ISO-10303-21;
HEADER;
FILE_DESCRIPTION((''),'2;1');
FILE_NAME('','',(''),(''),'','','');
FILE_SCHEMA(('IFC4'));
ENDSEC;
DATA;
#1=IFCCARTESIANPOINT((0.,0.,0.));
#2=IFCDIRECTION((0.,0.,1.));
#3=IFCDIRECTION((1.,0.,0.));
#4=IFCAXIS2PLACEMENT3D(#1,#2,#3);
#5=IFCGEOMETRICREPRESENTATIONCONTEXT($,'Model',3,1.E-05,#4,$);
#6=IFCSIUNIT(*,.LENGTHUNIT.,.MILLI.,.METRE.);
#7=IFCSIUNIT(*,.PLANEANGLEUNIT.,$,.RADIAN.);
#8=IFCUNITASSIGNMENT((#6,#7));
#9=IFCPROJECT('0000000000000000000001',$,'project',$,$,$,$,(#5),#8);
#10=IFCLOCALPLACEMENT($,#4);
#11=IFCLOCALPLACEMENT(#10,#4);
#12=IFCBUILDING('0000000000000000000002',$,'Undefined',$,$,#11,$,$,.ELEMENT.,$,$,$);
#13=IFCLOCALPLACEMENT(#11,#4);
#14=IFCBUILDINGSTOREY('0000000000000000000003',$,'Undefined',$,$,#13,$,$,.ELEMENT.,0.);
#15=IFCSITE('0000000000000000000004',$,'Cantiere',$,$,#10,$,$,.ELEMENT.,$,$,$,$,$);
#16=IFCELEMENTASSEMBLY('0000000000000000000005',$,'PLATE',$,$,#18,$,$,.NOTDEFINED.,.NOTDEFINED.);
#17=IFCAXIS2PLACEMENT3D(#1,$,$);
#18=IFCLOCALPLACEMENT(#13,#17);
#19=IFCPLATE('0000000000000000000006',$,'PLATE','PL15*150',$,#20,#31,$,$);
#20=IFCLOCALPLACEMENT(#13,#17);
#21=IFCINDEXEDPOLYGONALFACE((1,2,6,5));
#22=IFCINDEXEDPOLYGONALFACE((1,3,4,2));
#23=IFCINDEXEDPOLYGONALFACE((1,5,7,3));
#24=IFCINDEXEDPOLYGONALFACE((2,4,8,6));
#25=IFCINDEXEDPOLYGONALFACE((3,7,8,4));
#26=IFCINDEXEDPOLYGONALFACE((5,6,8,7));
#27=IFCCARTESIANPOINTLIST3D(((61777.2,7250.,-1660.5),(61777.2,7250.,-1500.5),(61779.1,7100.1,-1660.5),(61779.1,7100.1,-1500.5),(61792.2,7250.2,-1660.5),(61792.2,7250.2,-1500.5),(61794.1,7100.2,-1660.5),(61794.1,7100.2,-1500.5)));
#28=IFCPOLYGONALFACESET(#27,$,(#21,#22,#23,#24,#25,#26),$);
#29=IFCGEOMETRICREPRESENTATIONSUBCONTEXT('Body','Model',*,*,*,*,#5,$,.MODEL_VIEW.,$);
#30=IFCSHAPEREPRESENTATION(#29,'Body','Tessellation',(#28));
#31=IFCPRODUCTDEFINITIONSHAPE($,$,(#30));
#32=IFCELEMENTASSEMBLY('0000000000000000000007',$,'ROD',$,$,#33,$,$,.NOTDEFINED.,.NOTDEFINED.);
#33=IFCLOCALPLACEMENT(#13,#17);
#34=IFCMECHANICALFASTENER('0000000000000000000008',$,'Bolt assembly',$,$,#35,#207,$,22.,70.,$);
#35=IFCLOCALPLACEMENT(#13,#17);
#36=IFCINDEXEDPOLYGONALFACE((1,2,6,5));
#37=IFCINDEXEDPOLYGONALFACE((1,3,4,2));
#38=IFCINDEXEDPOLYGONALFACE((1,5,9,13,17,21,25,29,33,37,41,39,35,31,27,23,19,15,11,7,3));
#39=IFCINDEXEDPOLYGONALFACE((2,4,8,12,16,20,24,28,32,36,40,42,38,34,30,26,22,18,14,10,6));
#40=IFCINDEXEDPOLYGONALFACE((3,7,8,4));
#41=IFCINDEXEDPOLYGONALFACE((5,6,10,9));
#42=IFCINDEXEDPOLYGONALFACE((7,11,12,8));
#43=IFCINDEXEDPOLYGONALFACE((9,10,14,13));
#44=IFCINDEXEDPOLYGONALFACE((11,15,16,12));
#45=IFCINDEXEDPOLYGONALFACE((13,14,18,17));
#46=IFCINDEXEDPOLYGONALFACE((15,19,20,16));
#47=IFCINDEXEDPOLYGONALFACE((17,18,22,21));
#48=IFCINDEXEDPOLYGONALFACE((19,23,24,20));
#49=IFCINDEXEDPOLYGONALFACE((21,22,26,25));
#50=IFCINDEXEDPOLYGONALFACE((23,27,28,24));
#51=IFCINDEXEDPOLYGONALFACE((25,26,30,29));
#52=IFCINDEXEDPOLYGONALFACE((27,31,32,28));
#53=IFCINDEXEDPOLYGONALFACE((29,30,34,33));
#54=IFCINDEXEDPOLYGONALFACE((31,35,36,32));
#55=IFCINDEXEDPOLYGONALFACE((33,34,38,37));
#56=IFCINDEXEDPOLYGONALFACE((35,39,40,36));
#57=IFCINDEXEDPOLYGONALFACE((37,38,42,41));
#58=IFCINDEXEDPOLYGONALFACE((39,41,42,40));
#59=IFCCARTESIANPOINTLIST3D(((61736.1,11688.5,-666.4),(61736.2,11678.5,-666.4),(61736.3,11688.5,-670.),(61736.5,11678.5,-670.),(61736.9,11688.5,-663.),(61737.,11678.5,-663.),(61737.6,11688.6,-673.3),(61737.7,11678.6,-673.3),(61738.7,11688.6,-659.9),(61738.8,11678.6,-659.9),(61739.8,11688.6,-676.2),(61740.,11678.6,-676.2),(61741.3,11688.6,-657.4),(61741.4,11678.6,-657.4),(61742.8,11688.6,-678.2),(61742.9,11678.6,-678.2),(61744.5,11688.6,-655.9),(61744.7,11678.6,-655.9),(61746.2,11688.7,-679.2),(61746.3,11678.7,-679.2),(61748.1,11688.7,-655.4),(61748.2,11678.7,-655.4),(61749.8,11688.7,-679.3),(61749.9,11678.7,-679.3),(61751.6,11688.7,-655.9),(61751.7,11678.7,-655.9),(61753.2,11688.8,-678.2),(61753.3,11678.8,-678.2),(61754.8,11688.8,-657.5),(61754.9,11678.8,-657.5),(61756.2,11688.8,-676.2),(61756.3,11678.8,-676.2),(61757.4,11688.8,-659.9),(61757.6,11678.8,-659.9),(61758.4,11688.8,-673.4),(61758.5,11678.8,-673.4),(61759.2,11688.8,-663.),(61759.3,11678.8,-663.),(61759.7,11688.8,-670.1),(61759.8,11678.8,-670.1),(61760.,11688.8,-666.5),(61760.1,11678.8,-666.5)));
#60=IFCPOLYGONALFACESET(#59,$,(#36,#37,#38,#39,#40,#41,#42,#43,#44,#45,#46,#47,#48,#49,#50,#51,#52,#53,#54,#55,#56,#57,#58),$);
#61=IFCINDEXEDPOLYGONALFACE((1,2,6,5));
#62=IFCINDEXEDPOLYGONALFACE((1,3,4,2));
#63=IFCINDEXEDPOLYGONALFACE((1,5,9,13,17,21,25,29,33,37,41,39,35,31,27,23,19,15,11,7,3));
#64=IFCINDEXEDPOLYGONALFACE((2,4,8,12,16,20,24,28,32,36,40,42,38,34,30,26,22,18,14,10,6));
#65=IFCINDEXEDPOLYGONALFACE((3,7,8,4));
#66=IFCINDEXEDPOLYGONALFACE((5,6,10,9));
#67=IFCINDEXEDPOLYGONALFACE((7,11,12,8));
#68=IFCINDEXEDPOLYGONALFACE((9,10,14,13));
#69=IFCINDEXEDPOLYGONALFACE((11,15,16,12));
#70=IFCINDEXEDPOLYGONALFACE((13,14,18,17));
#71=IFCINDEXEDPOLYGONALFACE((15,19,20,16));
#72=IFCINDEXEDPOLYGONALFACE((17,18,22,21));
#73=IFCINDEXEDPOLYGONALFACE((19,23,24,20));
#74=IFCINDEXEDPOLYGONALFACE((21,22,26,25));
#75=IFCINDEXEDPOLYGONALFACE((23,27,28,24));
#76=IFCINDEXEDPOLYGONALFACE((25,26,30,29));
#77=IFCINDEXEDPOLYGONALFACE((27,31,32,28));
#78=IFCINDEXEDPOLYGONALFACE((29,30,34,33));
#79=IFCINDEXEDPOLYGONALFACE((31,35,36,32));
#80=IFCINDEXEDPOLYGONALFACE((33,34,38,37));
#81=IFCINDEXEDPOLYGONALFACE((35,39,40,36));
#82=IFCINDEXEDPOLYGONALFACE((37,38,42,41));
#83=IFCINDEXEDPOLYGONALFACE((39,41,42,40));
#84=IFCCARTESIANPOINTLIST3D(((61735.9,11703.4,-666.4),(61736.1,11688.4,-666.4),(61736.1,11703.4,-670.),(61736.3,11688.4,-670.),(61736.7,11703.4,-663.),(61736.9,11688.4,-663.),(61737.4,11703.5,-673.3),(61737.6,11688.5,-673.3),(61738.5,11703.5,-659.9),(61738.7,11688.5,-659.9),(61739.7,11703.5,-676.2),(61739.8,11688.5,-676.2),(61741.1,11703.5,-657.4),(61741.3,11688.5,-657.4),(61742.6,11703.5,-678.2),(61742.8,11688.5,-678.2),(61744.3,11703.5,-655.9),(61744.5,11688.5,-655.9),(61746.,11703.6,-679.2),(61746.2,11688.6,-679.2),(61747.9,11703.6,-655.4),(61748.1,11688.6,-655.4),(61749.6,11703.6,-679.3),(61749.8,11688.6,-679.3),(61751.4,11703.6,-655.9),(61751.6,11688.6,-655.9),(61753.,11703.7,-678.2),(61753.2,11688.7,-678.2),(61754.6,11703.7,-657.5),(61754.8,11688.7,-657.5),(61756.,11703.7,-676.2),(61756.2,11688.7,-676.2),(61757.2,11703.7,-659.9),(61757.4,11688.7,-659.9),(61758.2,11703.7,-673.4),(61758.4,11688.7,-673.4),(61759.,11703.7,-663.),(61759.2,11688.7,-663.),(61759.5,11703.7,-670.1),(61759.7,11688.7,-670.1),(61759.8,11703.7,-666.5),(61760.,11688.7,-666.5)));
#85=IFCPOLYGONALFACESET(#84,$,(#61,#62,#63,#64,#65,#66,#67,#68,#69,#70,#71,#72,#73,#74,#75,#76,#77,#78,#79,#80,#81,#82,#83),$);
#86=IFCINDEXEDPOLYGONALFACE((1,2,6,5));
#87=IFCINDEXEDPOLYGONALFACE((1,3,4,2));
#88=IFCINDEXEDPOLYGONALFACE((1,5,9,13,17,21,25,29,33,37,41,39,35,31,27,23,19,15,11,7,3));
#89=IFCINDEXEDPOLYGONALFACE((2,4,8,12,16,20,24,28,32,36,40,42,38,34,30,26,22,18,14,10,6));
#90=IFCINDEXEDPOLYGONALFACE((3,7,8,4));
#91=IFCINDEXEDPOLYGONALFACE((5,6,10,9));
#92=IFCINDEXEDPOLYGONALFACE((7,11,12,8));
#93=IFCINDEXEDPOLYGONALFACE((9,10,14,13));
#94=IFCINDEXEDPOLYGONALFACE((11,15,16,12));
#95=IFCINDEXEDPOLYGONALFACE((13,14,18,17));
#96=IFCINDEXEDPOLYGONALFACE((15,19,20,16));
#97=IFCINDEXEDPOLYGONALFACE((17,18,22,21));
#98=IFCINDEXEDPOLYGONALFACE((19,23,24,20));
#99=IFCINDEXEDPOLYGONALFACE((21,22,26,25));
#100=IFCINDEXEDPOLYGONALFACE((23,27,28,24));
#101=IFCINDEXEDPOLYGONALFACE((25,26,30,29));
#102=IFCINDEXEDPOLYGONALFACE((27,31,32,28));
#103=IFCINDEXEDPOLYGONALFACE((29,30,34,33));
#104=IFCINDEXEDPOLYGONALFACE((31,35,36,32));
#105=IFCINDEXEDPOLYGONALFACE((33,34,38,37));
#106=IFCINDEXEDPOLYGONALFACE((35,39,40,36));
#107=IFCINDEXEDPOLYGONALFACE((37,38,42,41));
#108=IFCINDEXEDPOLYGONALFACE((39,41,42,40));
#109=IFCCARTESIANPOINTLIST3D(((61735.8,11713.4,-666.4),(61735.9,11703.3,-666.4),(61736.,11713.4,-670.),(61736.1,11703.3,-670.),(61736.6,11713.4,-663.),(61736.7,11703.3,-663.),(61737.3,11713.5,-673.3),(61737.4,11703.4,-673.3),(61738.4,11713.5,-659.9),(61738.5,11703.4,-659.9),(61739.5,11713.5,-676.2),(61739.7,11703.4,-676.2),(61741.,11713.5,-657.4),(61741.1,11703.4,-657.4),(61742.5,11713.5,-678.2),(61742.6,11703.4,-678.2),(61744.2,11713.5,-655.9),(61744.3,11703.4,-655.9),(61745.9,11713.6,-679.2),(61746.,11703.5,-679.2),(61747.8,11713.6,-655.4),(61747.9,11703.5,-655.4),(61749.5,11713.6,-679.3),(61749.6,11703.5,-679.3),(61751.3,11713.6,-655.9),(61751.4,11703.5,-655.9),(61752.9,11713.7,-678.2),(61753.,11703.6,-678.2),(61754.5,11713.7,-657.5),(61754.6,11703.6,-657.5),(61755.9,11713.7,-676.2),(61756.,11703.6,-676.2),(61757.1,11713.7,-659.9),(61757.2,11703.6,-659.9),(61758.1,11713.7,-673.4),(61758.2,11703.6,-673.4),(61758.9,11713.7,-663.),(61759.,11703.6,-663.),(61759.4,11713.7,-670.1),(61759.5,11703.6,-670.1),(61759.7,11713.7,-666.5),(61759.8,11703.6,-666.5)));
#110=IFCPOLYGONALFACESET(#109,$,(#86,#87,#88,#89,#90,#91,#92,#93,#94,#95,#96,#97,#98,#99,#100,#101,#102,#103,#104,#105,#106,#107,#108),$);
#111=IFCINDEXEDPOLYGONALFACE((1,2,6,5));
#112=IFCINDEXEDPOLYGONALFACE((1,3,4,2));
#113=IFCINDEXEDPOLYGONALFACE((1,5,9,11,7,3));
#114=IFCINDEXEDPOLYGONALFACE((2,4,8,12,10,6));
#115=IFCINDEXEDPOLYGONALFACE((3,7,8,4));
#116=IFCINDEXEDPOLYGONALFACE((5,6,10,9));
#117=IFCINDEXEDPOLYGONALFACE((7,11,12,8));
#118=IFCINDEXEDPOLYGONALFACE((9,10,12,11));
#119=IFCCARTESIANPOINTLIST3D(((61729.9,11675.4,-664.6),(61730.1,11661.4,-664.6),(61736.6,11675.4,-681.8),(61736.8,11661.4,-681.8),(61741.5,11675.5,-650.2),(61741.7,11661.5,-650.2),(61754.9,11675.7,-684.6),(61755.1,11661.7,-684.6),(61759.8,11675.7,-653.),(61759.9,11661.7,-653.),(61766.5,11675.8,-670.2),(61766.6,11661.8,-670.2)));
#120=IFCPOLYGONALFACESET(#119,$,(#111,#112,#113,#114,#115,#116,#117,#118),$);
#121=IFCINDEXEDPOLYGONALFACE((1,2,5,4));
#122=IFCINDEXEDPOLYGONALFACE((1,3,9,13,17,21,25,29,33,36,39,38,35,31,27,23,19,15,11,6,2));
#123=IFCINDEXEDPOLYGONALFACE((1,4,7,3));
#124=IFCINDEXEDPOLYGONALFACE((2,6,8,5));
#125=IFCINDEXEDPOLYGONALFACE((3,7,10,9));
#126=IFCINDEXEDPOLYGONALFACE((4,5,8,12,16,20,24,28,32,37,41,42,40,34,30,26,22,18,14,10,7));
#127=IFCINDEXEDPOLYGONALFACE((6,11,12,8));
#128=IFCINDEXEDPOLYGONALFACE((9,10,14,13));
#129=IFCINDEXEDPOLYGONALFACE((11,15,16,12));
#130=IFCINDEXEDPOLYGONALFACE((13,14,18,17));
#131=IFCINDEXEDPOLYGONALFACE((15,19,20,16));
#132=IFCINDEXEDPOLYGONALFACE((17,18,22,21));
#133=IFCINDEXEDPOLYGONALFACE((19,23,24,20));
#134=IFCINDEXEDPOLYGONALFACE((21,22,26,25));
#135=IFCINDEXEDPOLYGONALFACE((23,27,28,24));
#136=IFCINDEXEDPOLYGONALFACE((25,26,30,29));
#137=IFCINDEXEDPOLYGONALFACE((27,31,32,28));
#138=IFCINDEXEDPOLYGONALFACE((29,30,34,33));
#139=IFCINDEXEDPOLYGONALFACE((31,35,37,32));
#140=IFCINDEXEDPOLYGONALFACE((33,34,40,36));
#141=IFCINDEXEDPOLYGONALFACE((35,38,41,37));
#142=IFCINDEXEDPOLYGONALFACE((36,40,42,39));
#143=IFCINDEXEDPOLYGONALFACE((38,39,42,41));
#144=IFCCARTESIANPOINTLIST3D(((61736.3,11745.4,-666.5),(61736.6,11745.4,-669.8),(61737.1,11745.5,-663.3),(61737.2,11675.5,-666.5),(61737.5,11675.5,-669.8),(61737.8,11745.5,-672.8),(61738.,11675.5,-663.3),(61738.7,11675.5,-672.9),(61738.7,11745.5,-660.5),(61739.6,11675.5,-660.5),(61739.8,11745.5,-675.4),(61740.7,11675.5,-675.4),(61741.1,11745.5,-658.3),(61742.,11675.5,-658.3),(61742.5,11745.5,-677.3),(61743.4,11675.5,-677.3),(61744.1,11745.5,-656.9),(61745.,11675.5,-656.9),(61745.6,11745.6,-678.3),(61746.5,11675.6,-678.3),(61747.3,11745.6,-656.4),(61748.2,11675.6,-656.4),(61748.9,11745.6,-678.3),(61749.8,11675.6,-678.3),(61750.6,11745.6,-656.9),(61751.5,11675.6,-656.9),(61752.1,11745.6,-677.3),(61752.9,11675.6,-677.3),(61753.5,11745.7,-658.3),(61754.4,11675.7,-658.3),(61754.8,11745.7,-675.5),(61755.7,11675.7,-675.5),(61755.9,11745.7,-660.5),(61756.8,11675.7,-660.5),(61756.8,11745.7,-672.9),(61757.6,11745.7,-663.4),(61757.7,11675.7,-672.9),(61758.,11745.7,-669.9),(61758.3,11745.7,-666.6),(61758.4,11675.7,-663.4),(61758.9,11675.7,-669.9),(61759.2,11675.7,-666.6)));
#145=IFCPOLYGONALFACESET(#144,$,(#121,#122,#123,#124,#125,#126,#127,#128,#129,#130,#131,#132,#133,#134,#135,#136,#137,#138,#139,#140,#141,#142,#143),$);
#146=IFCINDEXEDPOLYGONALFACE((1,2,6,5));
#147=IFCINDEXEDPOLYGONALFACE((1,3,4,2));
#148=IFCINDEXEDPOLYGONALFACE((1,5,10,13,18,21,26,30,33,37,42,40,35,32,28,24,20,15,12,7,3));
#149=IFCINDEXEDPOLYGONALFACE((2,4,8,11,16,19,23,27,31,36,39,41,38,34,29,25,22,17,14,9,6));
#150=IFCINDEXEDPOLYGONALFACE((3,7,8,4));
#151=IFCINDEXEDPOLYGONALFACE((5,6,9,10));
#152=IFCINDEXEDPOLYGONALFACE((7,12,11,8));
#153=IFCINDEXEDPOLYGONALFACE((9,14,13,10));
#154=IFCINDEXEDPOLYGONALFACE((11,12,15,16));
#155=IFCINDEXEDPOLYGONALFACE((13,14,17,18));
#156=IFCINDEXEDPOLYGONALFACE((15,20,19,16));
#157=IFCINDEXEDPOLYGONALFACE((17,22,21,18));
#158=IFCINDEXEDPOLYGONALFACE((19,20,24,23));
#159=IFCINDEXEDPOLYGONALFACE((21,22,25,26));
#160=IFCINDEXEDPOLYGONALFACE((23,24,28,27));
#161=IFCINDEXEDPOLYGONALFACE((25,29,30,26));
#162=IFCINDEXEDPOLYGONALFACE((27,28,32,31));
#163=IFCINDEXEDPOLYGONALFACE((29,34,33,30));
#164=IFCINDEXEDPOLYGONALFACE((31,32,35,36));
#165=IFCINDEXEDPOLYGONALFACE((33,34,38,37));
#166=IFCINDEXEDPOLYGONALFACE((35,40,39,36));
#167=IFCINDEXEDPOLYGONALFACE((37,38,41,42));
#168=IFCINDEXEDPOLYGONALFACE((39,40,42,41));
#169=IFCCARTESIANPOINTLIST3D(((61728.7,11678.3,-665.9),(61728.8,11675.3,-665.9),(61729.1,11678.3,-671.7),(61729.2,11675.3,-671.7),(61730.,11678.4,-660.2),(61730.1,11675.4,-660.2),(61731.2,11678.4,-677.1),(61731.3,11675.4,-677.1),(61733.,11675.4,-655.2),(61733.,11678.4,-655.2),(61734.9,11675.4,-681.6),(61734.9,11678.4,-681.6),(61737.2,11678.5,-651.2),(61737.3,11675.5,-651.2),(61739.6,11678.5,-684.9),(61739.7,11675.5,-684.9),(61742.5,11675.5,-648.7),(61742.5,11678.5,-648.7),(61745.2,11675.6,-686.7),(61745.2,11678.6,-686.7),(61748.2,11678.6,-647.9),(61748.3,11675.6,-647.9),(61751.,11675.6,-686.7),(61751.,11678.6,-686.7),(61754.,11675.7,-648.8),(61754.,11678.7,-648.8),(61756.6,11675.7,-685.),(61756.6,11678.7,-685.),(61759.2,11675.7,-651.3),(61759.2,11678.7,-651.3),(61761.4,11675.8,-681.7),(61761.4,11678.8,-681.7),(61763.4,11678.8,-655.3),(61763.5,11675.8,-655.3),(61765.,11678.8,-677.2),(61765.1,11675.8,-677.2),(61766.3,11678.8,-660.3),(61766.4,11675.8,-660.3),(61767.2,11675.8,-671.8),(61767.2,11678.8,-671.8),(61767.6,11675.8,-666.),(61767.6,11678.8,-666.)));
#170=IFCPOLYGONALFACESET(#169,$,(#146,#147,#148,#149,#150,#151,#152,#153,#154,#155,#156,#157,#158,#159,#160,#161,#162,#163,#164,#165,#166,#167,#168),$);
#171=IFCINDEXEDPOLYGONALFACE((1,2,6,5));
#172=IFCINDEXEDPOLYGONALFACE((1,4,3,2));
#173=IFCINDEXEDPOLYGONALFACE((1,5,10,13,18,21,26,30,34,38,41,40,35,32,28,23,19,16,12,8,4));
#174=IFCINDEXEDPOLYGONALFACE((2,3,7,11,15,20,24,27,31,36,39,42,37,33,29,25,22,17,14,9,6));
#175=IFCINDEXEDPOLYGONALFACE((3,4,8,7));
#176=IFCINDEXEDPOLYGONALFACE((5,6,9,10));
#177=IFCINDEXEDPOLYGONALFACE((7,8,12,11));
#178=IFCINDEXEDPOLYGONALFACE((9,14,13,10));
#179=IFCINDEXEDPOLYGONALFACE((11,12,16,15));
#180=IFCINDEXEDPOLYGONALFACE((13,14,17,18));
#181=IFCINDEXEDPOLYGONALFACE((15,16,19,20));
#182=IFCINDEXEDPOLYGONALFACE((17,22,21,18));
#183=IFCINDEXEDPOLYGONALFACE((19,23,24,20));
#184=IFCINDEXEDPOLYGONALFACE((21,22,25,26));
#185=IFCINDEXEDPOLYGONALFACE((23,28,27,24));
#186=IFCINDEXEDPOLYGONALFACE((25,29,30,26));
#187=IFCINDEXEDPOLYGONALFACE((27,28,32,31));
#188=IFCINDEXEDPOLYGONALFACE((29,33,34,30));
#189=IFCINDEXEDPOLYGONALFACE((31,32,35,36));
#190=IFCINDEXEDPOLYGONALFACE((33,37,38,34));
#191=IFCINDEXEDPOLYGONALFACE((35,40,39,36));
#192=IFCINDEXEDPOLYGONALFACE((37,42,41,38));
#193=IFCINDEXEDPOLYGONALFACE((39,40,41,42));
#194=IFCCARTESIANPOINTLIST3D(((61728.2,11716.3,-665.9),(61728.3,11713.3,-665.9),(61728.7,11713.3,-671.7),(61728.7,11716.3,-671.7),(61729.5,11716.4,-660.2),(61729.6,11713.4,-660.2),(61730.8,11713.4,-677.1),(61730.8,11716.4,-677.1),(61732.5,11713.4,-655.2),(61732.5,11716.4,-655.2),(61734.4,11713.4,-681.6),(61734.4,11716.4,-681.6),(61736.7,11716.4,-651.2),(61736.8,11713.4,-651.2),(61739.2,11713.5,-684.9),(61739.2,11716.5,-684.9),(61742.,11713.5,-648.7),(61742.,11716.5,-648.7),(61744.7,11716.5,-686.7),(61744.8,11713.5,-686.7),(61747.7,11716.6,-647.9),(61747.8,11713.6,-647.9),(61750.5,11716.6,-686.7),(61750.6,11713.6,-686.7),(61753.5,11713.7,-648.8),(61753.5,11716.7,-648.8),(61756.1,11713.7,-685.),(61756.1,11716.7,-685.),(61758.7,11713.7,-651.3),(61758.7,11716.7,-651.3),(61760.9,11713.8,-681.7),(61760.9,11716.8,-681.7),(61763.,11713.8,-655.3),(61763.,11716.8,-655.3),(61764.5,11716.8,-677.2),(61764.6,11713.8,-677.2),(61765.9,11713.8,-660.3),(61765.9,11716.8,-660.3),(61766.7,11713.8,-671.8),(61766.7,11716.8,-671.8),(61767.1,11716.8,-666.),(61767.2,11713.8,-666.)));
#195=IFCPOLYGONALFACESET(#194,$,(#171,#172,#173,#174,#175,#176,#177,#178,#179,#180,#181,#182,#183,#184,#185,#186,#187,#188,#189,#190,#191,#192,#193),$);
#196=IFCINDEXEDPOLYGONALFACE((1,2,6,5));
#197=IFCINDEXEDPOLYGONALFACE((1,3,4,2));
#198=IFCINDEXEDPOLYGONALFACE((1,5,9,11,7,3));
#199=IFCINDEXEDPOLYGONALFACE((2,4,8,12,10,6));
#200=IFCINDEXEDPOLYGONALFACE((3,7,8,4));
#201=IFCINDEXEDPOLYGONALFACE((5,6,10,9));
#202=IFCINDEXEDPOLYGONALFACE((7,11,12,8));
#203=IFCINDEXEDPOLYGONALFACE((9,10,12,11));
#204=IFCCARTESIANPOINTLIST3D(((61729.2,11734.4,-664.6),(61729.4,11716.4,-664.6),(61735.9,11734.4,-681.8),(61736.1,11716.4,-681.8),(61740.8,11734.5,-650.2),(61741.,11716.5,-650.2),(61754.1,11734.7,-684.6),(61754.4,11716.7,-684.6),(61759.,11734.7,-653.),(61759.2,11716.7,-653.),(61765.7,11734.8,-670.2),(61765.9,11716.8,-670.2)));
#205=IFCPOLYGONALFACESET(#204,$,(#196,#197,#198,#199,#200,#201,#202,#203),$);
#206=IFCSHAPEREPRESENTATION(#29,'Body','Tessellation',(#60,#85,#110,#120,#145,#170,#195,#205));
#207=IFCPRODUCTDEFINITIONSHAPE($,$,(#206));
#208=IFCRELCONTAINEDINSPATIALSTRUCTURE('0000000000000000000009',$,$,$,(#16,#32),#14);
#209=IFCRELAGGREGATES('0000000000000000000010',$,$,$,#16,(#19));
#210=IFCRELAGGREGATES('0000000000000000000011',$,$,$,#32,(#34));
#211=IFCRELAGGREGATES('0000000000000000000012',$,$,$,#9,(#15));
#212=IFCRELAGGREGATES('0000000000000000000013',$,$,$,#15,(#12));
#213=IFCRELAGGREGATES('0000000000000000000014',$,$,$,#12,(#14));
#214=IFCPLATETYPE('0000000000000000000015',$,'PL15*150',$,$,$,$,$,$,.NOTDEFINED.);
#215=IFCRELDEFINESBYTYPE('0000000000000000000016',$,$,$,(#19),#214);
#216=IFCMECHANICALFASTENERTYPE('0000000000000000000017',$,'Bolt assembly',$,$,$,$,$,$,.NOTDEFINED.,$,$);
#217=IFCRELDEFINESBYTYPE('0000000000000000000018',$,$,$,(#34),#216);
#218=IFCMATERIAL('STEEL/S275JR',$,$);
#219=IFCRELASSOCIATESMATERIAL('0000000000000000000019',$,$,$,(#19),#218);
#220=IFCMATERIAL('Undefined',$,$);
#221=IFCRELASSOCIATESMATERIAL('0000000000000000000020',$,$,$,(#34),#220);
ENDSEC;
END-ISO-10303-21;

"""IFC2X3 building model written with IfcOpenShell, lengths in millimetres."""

from ifc_helpers import new_model, si_unit, frame, origin_with_axes, origin_2d_with_axis, place, context, subcontext, project, spatial, polyline, circle, outline, extrude, source, transform, mapped, material, type_object, element, aggregate, save


model = new_model("IFC2X3")

# Units and contexts
model_context = context("Model", 3, precision=1e-05, world=origin_with_axes())
body_context = subcontext(model_context, "Body", "Model", "MODEL_VIEW")
ifc_project = project(units=[si_unit("LENGTHUNIT", "METRE", prefix="MILLI"), si_unit("PLANEANGLEUNIT", "RADIAN")], contexts=[model_context])

# Site, building, storey
site_placement = place(None, origin_with_axes())
site = spatial("IfcSite", under=ifc_project, at=site_placement, Name="Cantiere", CompositionType="ELEMENT")
building_placement = place(site_placement, origin_with_axes())
building = spatial("IfcBuilding", under=site, at=building_placement, Name="Undefined", CompositionType="ELEMENT")
storey_placement = place(building_placement, origin_with_axes())
storey = spatial("IfcBuildingStorey", under=building, at=storey_placement, Name="Undefined", CompositionType="ELEMENT", Elevation=0.0)

# Shared definitions
ifc_material_1 = material(Name="STEEL/S275JR")

# Element assembly, plate
assembly_1_placement = place(storey_placement, origin_with_axes())
assembly_1 = element("IfcElementAssembly", 1, at=assembly_1_placement, inside=storey, Name="PLATE", AssemblyPlace="NOTDEFINED", PredefinedType="NOTDEFINED")
plate_type_1 = type_object("IfcPlateType", Name="PL15*150", PredefinedType="NOTDEFINED")
plate_1_placement = place(assembly_1_placement, frame((61784.7, 7250.1, -1500.5), z_axis=(-0.99992, -0.012617, 0.0), x_axis=(0.0, 0.000001, -1.0)))
plate_1 = element("IfcPlate", 2, at=plate_1_placement, type_object=plate_type_1, material=ifc_material_1, Name="PLATE", Description="PL15*150", context=body_context, shape_type="SweptSolid", body=[
    extrude(outline(polyline([(0.0, 0.0), (160.0, 0.0), (160.0, 150.0), (0.0, 150.0), (0.0, 0.0)])), frame((0.0, 0.0, -7.5), z_axis=(0.0, 0.0, 1.0), x_axis=(1.0, 0.0, 0.0)), (0.0, 0.0, 1.0), 15.0),
])
aggregate(assembly_1, [plate_1])

# Element assembly, mechanical fastener
assembly_2_placement = place(storey_placement, origin_with_axes())
assembly_2 = element("IfcElementAssembly", 3, at=assembly_2_placement, inside=storey, Name="ROD", AssemblyPlace="NOTDEFINED", PredefinedType="NOTDEFINED")
ifc_material_2 = material(Name="Undefined")
mechanical_fastener_type = type_object("IfcMechanicalFastenerType", Name="Bolt assembly")
shared_shape_1 = source(origin_with_axes(), body_context, "Body", "SweptSolid", [
    extrude(circle(Radius=12.0, at=origin_2d_with_axis()), frame((0.0, 0.1, 0.0), z_axis=(0.0, 1.0, 0.0), x_axis=(1.0, 0.0, 0.0)), (0.0, 0.0, 1.0), 10.0),
    extrude(circle(Radius=12.0, at=origin_2d_with_axis()), frame((0.0, 10.0, 0.0), z_axis=(0.0, 1.0, 0.0), x_axis=(1.0, 0.0, 0.0)), (0.0, 0.0, 1.0), 15.0),
    extrude(circle(Radius=12.0, at=origin_2d_with_axis()), frame((0.0, 24.9, 0.0), z_axis=(0.0, 1.0, 0.0), x_axis=(1.0, 0.0, 0.0)), (0.0, 0.0, 1.0), 10.1),
    extrude(outline(polyline([(16.0, -9.2), (16.0, 9.2), (0.0, 18.5), (-16.0, 9.2), (-16.0, -9.2), (0.0, -18.5), (16.0, -9.2)])), frame((0.0, -17.0, 0.0), z_axis=(0.0, 1.0, 0.0), x_axis=(1.0, 0.0, 0.0)), (0.0, 0.0, 1.0), 14.0),
    extrude(circle(Radius=11.0, at=origin_2d_with_axis()), frame((0.0, -3.0, 0.0), z_axis=(0.0, 1.0, 0.0), x_axis=(1.0, 0.0, 0.0)), (0.0, 0.0, 1.0), 70.0),
    extrude(circle(Radius=19.5, at=origin_2d_with_axis()), frame((0.0, -3.0, 0.0), z_axis=(0.0, 1.0, 0.0), x_axis=(1.0, 0.0, 0.0)), (0.0, 0.0, 1.0), 3.0),
    extrude(circle(Radius=19.5, at=origin_2d_with_axis()), frame((0.0, 35.0, 0.0), z_axis=(0.0, 1.0, 0.0), x_axis=(1.0, 0.0, 0.0)), (0.0, 0.0, 1.0), 3.0),
    extrude(outline(polyline([(16.0, -9.2), (16.0, 9.2), (0.0, 18.5), (-16.0, 9.2), (-16.0, -9.2), (0.0, -18.5), (16.0, -9.2)])), frame((0.0, 38.0, 0.0), z_axis=(0.0, 1.0, 0.0), x_axis=(1.0, 0.0, 0.0)), (0.0, 0.0, 1.0), 18.0),
])
mechanical_fastener_1_placement = place(assembly_2_placement, frame((61748.2, 11678.6, -667.4), z_axis=(-0.362433, -0.004577, 0.931999), x_axis=(0.931925, 0.011758, 0.362462)))
mechanical_fastener_1 = element("IfcMechanicalFastener", 4, at=mechanical_fastener_1_placement, type_object=mechanical_fastener_type, material=ifc_material_2, Name="Bolt assembly", NominalDiameter=22.0, NominalLength=70.0, context=body_context, shape_type="MappedRepresentation", body=[
    mapped(shared_shape_1, transform((0.0, 0.0, 0.0))),
])
aggregate(assembly_2, [mechanical_fastener_1])

save(model, "model.ifc")
